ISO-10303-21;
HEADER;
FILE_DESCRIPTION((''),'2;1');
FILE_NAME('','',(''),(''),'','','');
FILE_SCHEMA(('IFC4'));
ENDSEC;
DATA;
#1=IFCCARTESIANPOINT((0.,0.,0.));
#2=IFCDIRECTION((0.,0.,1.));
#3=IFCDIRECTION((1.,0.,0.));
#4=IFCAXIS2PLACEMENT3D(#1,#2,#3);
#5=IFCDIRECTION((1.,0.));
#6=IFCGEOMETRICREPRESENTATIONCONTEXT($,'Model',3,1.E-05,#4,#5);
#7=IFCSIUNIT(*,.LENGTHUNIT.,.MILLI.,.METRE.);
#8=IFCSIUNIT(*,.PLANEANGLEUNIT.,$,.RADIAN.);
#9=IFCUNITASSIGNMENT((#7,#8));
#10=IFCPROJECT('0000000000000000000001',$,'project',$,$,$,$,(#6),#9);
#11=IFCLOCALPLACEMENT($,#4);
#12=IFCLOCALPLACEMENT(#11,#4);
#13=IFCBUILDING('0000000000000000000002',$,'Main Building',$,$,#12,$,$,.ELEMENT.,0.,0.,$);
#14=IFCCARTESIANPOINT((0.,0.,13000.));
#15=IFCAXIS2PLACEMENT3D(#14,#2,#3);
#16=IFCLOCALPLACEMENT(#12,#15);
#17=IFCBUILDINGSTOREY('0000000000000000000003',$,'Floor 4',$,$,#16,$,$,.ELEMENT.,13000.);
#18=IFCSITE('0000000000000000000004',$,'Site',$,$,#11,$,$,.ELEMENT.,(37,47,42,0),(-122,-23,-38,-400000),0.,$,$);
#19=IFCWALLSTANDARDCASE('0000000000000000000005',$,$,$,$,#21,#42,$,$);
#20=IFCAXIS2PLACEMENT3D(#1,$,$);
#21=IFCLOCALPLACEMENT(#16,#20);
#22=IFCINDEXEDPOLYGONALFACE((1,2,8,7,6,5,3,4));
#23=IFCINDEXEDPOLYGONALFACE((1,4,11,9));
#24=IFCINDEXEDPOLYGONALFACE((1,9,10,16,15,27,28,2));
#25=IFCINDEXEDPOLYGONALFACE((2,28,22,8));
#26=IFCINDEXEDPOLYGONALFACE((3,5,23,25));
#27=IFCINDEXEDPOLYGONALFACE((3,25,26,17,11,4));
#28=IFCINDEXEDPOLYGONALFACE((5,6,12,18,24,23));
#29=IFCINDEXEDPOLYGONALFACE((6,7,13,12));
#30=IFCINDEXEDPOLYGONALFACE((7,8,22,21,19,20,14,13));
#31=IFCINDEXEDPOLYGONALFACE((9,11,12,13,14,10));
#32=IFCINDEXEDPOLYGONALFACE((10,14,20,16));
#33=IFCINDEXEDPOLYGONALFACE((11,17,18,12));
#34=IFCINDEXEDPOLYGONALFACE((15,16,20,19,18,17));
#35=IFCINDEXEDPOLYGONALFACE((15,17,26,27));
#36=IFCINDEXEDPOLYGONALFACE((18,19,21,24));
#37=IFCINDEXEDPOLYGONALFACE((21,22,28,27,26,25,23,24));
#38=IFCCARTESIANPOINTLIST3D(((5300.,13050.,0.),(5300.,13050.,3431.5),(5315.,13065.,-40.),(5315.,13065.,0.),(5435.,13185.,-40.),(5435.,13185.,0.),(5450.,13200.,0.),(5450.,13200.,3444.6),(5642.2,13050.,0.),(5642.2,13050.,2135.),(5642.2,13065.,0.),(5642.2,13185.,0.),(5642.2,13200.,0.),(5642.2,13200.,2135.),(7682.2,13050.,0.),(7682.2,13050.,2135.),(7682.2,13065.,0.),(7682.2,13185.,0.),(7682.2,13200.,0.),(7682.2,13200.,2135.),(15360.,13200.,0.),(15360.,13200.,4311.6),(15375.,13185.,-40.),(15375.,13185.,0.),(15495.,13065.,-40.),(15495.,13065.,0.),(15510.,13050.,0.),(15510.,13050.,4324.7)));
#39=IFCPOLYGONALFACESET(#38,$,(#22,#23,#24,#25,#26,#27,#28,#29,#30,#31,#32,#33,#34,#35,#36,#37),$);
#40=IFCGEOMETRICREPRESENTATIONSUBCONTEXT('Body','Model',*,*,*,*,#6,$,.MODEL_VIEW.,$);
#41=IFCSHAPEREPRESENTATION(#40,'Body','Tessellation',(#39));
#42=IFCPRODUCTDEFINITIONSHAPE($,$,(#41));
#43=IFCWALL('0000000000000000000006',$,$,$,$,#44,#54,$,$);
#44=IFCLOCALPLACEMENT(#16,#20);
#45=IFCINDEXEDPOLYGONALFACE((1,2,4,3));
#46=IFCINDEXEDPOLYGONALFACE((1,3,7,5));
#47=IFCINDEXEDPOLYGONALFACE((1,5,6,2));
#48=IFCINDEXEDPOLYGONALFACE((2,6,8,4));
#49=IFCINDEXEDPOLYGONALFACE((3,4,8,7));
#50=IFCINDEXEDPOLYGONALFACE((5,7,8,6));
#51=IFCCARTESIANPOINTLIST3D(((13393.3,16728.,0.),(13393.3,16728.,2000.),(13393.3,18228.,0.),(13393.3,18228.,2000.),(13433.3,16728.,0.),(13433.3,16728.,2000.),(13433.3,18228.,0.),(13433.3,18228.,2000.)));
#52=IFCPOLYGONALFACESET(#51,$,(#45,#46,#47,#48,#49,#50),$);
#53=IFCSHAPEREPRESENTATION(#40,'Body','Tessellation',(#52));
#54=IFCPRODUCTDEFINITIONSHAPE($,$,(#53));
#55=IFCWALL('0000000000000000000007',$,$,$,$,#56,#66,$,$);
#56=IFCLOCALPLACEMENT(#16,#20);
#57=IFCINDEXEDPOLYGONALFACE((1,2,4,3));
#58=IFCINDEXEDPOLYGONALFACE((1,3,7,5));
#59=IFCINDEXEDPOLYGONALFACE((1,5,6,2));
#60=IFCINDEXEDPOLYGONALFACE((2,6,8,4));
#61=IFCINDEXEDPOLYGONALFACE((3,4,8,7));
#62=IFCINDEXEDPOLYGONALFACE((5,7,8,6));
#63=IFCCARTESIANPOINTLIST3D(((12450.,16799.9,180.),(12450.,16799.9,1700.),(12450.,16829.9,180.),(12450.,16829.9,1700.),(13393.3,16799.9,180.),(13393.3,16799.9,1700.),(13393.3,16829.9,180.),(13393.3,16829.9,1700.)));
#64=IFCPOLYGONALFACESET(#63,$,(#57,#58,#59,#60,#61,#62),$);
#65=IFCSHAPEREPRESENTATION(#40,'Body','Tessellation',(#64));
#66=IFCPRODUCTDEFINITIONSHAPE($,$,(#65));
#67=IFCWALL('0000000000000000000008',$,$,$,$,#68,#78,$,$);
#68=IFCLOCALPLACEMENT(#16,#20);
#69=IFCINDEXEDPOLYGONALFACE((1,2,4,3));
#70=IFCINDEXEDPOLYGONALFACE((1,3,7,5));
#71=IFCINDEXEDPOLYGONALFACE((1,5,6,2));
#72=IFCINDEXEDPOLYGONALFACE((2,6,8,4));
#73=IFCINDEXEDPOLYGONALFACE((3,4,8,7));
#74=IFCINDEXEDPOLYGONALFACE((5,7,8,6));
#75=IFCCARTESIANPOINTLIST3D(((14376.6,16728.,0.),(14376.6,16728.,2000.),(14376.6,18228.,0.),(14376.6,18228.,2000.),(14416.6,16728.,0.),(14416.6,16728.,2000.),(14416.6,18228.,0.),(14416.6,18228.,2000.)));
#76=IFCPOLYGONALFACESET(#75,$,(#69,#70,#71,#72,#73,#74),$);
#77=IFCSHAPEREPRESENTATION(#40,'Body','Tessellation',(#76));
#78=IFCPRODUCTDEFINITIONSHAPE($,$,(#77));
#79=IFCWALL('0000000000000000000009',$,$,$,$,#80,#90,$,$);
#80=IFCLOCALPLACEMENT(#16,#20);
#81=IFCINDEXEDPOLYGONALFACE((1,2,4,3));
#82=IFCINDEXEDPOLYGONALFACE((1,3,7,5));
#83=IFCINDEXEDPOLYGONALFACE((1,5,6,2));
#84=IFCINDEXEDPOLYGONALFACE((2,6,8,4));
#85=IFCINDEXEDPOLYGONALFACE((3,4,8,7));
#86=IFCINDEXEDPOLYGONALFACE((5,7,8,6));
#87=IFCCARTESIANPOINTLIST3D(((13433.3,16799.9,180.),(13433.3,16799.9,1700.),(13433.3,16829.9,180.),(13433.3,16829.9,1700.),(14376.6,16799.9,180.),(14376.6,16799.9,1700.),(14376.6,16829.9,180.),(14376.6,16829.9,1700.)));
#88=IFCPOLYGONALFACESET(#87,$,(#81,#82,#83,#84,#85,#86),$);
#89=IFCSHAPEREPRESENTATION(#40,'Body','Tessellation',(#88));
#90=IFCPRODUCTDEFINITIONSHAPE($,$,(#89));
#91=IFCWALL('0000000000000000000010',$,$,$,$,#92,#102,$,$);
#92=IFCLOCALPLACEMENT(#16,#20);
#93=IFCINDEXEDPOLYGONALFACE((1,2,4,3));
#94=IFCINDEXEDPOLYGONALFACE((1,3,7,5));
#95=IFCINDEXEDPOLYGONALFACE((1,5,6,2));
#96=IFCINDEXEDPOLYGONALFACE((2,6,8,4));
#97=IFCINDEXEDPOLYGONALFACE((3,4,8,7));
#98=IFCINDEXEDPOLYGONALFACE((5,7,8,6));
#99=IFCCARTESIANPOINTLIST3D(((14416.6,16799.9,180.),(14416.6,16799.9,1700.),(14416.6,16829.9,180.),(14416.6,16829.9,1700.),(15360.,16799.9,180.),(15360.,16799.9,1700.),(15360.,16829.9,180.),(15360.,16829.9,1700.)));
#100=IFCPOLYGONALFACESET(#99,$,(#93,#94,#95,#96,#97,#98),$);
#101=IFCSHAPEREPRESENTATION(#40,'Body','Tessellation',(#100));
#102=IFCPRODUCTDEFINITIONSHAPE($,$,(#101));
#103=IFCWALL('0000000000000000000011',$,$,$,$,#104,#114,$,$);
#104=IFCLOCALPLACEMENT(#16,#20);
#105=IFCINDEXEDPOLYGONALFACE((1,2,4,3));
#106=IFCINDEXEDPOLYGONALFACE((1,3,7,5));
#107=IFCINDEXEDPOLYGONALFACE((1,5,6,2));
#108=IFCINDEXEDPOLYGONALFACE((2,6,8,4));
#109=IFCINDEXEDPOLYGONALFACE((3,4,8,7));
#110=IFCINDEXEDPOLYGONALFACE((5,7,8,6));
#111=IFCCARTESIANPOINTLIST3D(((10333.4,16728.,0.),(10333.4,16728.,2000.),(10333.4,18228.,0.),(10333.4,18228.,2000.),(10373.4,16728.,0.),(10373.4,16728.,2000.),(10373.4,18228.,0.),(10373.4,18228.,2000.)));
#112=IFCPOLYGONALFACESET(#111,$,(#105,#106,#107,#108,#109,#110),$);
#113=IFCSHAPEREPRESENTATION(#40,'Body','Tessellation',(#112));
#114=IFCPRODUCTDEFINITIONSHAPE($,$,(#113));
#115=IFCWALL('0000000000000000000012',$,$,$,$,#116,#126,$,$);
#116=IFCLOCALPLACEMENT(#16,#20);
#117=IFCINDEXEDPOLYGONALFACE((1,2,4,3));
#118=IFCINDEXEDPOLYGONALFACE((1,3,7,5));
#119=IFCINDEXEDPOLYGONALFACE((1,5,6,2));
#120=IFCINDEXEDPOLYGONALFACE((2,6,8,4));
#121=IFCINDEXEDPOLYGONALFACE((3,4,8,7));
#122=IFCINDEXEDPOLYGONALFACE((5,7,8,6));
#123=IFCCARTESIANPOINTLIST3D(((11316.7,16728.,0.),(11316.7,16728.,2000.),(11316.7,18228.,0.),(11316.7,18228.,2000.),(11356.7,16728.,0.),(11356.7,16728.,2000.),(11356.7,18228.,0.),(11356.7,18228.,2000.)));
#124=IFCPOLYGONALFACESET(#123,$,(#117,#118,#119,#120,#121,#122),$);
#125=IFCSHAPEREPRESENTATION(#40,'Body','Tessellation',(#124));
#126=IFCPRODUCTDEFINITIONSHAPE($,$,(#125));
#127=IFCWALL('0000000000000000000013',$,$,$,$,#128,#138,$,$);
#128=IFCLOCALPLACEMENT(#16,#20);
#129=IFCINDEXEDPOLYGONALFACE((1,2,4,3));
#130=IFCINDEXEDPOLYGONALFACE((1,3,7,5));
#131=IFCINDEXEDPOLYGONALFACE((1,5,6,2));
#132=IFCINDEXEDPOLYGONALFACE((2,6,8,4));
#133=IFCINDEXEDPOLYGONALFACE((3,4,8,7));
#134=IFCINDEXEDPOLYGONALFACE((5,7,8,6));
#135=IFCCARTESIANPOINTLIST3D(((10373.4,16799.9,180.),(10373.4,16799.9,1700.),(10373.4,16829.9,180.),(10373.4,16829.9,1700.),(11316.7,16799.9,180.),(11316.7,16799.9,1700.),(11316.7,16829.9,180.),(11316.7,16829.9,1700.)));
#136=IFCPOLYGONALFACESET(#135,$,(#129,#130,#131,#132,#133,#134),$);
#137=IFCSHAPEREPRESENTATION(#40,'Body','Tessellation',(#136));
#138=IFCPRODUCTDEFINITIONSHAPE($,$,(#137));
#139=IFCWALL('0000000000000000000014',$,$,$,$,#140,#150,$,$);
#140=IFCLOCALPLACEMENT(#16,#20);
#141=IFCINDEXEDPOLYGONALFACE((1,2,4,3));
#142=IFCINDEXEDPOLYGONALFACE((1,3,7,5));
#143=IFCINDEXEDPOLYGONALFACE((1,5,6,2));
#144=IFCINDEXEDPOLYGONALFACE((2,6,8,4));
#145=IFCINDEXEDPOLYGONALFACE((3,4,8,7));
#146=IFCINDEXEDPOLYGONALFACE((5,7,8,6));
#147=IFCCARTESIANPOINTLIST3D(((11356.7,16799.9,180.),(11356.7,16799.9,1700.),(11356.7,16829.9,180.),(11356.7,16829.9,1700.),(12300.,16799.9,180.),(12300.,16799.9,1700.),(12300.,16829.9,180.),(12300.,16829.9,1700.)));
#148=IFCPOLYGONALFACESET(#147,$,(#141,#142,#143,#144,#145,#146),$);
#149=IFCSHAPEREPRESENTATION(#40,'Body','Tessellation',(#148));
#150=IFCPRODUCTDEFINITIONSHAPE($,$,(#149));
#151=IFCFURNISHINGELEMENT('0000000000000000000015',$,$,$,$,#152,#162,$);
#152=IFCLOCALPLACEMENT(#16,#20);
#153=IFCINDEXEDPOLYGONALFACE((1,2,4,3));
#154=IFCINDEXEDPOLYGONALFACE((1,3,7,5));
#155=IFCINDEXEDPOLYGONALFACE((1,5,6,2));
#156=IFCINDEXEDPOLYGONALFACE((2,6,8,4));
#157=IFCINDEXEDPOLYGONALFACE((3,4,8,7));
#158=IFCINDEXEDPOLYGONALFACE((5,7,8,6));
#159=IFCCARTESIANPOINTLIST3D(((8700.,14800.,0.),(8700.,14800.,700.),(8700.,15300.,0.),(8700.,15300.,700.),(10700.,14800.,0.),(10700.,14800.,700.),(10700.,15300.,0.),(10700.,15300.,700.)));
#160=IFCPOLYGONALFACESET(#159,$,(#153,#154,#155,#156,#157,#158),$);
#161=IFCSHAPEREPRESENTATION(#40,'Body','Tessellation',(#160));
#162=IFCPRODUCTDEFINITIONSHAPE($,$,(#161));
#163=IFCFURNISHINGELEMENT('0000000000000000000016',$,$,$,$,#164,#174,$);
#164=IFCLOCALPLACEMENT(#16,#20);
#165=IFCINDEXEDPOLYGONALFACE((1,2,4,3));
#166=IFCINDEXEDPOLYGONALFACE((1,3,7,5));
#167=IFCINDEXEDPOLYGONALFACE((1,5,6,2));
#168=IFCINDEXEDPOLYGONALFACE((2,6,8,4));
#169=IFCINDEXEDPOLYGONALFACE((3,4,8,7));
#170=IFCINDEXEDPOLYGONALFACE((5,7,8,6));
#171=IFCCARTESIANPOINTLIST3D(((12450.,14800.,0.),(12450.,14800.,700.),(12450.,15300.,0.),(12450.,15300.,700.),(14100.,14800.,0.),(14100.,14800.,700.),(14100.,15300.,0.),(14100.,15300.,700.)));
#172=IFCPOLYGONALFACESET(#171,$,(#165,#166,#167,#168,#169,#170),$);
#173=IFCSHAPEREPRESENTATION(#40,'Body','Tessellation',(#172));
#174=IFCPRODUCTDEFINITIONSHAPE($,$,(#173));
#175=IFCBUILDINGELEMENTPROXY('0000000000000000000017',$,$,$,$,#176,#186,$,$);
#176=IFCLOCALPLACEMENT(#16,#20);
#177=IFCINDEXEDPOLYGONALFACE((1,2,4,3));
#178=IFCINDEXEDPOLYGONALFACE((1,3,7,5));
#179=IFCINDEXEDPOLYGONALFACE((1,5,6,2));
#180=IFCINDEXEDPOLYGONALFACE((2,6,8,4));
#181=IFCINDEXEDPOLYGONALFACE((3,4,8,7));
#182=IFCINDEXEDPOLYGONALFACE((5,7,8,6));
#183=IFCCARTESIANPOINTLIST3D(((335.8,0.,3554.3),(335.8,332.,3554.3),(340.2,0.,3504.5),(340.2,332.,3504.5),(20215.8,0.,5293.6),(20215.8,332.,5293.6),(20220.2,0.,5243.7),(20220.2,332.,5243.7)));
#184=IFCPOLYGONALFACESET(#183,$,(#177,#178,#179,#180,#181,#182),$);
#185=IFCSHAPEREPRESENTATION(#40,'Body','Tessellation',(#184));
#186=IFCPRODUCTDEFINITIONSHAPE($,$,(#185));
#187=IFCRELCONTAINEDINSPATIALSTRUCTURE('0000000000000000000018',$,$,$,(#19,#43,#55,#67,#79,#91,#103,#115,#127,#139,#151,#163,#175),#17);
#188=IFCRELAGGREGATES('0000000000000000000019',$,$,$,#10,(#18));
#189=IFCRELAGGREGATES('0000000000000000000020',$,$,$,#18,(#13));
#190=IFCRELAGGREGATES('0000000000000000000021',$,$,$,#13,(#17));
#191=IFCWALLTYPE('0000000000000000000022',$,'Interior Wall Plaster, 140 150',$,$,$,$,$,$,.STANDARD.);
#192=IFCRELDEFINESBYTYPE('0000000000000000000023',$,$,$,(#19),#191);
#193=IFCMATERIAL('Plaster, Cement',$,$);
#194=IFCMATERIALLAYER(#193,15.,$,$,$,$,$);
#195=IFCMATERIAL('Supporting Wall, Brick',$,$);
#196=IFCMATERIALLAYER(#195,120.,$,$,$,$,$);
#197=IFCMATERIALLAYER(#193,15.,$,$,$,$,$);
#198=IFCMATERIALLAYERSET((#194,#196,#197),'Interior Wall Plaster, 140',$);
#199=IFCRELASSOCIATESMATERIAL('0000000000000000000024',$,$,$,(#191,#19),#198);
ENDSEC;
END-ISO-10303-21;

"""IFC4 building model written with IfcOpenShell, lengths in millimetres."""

from ifc_helpers import new_model, si_unit, direction, frame, frame_2d, origin_with_axes, origin_2d_with_axis, place, context, subcontext, project, spatial, polyline, rectangle, outline, extrude, clip, bounded_halfspace, material, layer, layer_set, layer_usage, type_object, element, save


model = new_model("IFC4")

# Units and contexts
model_context = context("Model", 3, precision=1e-05, world=origin_with_axes(), true_north=direction((1.0, 0.0)))
body_context = subcontext(model_context, "Body", "Model", "MODEL_VIEW")
ifc_project = project(units=[si_unit("LENGTHUNIT", "METRE", prefix="MILLI"), si_unit("PLANEANGLEUNIT", "RADIAN")], contexts=[model_context])

# Site, building, storey
site_placement = place(None, origin_with_axes())
site = spatial("IfcSite", under=ifc_project, at=site_placement, Name="Site", CompositionType="ELEMENT", RefLatitude=(37, 47, 42, 0), RefLongitude=(-122, -23, -38, -400000), RefElevation=0.0)
building_placement = place(site_placement, origin_with_axes())
building = spatial("IfcBuilding", under=site, at=building_placement, Name="Main Building", CompositionType="ELEMENT", ElevationOfRefHeight=0.0, ElevationOfTerrain=0.0)
storey_placement = place(building_placement, frame((0.0, 0.0, 13000.0), z_axis=(0.0, 0.0, 1.0), x_axis=(1.0, 0.0, 0.0)))
storey = spatial("IfcBuildingStorey", under=building, at=storey_placement, Name="Floor 4", CompositionType="ELEMENT", Elevation=13000.0)

# Shared definitions
ifc_material_1 = material(Name="Supporting Wall, Brick")

# Shared definitions
ifc_material_2 = material(Name="Plaster, Cement")
ifc_layer_1 = layer(ifc_material_2, 15.0)
ifc_layer_2 = layer(ifc_material_1, 120.0)
ifc_layer_3 = layer(ifc_material_2, 15.0)
ifc_layer_set_1 = layer_set([ifc_layer_1, ifc_layer_2, ifc_layer_3], Name="Interior Wall Plaster, 140")
wall_type_1 = type_object("IfcWallType", Name="Interior Wall Plaster, 140 150", PredefinedType="STANDARD", material=ifc_layer_set_1)

# Wall, opening
ifc_layer_usage_1 = layer_usage(ifc_layer_set_1, "AXIS2", "POSITIVE", 0.0)
wall_1_placement = place(storey_placement, frame((5300.0, 13050.0, -40.0), z_axis=(0.0, 0.0, 1.0), x_axis=(1.0, 0.0, 0.0)))
wall_1 = element("IfcWallStandardCase", 1, at=wall_1_placement, inside=storey, type_object=wall_type_1, material=ifc_layer_usage_1, context=body_context, shape_type="Clipping", body=[
    clip(clip(clip(extrude(outline(polyline([(-4955.0, 75.0), (4955.0, 75.0), (5105.0, -75.0), (-5105.0, -75.0), (-4955.0, 75.0)])), frame((5105.0, 75.0, 0.0), z_axis=(0.0, 0.0, 1.0), x_axis=(1.0, 0.0, 0.0)), (0.0, 0.0, 1.0), 4364.7), bounded_halfspace(frame((-5300.0, -13050.0, 40.0), z_axis=(0.0, 0.0, -1.0), x_axis=(-1.0, 0.0, 0.0)), False, frame((5105.0, 75.0, 0.0), z_axis=(0.0, 0.0, 1.0), x_axis=(1.0, 0.0, 0.0)), polyline([(-4955.0, 75.0), (4955.0, 75.0), (4970.0, 60.0), (-4970.0, 60.0), (-4955.0, 75.0)]))), bounded_halfspace(frame((-5300.0, -13050.0, 40.0), z_axis=(0.0, 0.0, -1.0), x_axis=(-1.0, 0.0, 0.0)), False, frame((5105.0, 75.0, 0.0), z_axis=(0.0, 0.0, 1.0), x_axis=(1.0, 0.0, 0.0)), polyline([(-5090.0, -60.0), (5090.0, -60.0), (5105.0, -75.0), (-5105.0, -75.0), (-5090.0, -60.0)]))), bounded_halfspace(frame((-6686.4, -13050.0, 2886.5), z_axis=(-0.087156, 0.0, 0.996195), x_axis=(0.0, -1.0, 0.0)), False, frame((5105.0, 75.0, 0.0), z_axis=(0.0, 0.0, 1.0), x_axis=(1.0, 0.0, 0.0)), polyline([(4955.0, 75.0), (-4955.0, 75.0), (-5105.0, -75.0), (5105.0, -75.0), (4955.0, 75.0)]))),
])
opening_1_placement = place(wall_1_placement, frame((2382.2, 150.0, 40.0), z_axis=(0.0, 0.0, 1.0), x_axis=(-1.0, 0.0, 0.0)))
element("IfcOpeningElement", 2, at=opening_1_placement, cuts=wall_1, ObjectType="Opening", context=body_context, shape_type="SweptSolid", body=[
    extrude(outline(polyline([(-1020.0, -1067.5), (-1020.0, 1067.5), (1020.0, 1067.5), (1020.0, -1067.5), (-1020.0, -1067.5)])), frame((1020.0, 0.0, 1067.5), z_axis=(0.0, 1.0, 0.0), x_axis=(1.0, 0.0, 0.0)), (0.0, 0.0, 1.0), 1000.0),
])

# Walls
wall_2_placement = place(storey_placement, origin_with_axes())
element("IfcWall", 3, at=wall_2_placement, inside=storey, context=body_context, shape_type="SweptSolid", body=[
    extrude(rectangle(XDim=1500.0, YDim=40.0, at=frame_2d((0.0, 0.0), x_axis=(0.0, 1.0))), frame((13413.3, 17478.0, 0.0), z_axis=(0.0, 0.0, 1.0), x_axis=(1.0, 0.0, 0.0)), (0.0, 0.0, 1.0), 2000.0),
])
wall_3_placement = place(storey_placement, origin_with_axes())
element("IfcWall", 4, at=wall_3_placement, inside=storey, context=body_context, shape_type="SweptSolid", body=[
    extrude(rectangle(XDim=943.3, YDim=30.0, at=origin_2d_with_axis()), frame((12921.7, 16814.9, 180.0), z_axis=(0.0, 0.0, 1.0), x_axis=(1.0, 0.0, 0.0)), (0.0, 0.0, 1.0), 1520.0),
])
wall_4_placement = place(storey_placement, origin_with_axes())
element("IfcWall", 5, at=wall_4_placement, inside=storey, context=body_context, shape_type="SweptSolid", body=[
    extrude(rectangle(XDim=1500.0, YDim=40.0, at=frame_2d((0.0, 0.0), x_axis=(0.0, 1.0))), frame((14396.6, 17478.0, 0.0), z_axis=(0.0, 0.0, 1.0), x_axis=(1.0, 0.0, 0.0)), (0.0, 0.0, 1.0), 2000.0),
])
wall_5_placement = place(storey_placement, origin_with_axes())
element("IfcWall", 6, at=wall_5_placement, inside=storey, context=body_context, shape_type="SweptSolid", body=[
    extrude(rectangle(XDim=943.3, YDim=30.0, at=origin_2d_with_axis()), frame((13905.0, 16814.9, 180.0), z_axis=(0.0, 0.0, 1.0), x_axis=(1.0, 0.0, 0.0)), (0.0, 0.0, 1.0), 1520.0),
])
wall_6_placement = place(storey_placement, origin_with_axes())
element("IfcWall", 7, at=wall_6_placement, inside=storey, context=body_context, shape_type="SweptSolid", body=[
    extrude(rectangle(XDim=943.3, YDim=30.0, at=origin_2d_with_axis()), frame((14888.3, 16814.9, 180.0), z_axis=(0.0, 0.0, 1.0), x_axis=(1.0, 0.0, 0.0)), (0.0, 0.0, 1.0), 1520.0),
])
wall_7_placement = place(storey_placement, origin_with_axes())
element("IfcWall", 8, at=wall_7_placement, inside=storey, context=body_context, shape_type="SweptSolid", body=[
    extrude(rectangle(XDim=1500.0, YDim=40.0, at=frame_2d((0.0, 0.0), x_axis=(0.0, 1.0))), frame((10353.4, 17478.0, 0.0), z_axis=(0.0, 0.0, 1.0), x_axis=(1.0, 0.0, 0.0)), (0.0, 0.0, 1.0), 2000.0),
])
wall_8_placement = place(storey_placement, origin_with_axes())
element("IfcWall", 9, at=wall_8_placement, inside=storey, context=body_context, shape_type="SweptSolid", body=[
    extrude(rectangle(XDim=1500.0, YDim=40.0, at=frame_2d((0.0, 0.0), x_axis=(0.0, 1.0))), frame((11336.7, 17478.0, 0.0), z_axis=(0.0, 0.0, 1.0), x_axis=(1.0, 0.0, 0.0)), (0.0, 0.0, 1.0), 2000.0),
])
wall_9_placement = place(storey_placement, origin_with_axes())
element("IfcWall", 10, at=wall_9_placement, inside=storey, context=body_context, shape_type="SweptSolid", body=[
    extrude(rectangle(XDim=943.3, YDim=30.0, at=origin_2d_with_axis()), frame((10845.0, 16814.9, 180.0), z_axis=(0.0, 0.0, 1.0), x_axis=(1.0, 0.0, 0.0)), (0.0, 0.0, 1.0), 1520.0),
])
wall_10_placement = place(storey_placement, origin_with_axes())
element("IfcWall", 11, at=wall_10_placement, inside=storey, context=body_context, shape_type="SweptSolid", body=[
    extrude(rectangle(XDim=943.3, YDim=30.0, at=origin_2d_with_axis()), frame((11828.3, 16814.9, 180.0), z_axis=(0.0, 0.0, 1.0), x_axis=(1.0, 0.0, 0.0)), (0.0, 0.0, 1.0), 1520.0),
])

# Furnishing elements
furnishing_1_placement = place(storey_placement, frame((8700.0, 14800.0, 0.0), z_axis=(0.0, 0.0, 1.0), x_axis=(1.0, 0.0, 0.0)))
element("IfcFurnishingElement", 12, at=furnishing_1_placement, inside=storey, context=body_context, shape_type="SweptSolid", body=[
    extrude(rectangle(XDim=2000.0, YDim=500.0, at=origin_2d_with_axis()), frame((1000.0, 250.0, 0.0), z_axis=(0.0, 0.0, 1.0), x_axis=(1.0, 0.0, 0.0)), (0.0, 0.0, 1.0), 700.0),
])
furnishing_2_placement = place(storey_placement, frame((12450.0, 14800.0, 0.0), z_axis=(0.0, 0.0, 1.0), x_axis=(1.0, 0.0, 0.0)))
element("IfcFurnishingElement", 13, at=furnishing_2_placement, inside=storey, context=body_context, shape_type="SweptSolid", body=[
    extrude(rectangle(XDim=1650.0, YDim=500.0, at=origin_2d_with_axis()), frame((825.0, 250.0, 0.0), z_axis=(0.0, 0.0, 1.0), x_axis=(1.0, 0.0, 0.0)), (0.0, 0.0, 1.0), 700.0),
])

# Building element proxy
proxy_1_placement = place(storey_placement, frame((335.8, 0.0, 3504.5), z_axis=(0.0, 0.0, 1.0), x_axis=(1.0, 0.0, 0.0)))
element("IfcBuildingElementProxy", 14, at=proxy_1_placement, inside=storey, context=body_context, shape_type="SweptSolid", body=[
    extrude(rectangle(XDim=19956.0, YDim=332.0, at=origin_2d_with_axis()), frame((9944.4, 166.0, 869.6), z_axis=(-0.087156, 0.0, 0.996195), x_axis=(0.996195, 0.0, 0.087156)), (0.0, 0.0, 1.0), 50.0),
])

save(model, "model.ifc")
